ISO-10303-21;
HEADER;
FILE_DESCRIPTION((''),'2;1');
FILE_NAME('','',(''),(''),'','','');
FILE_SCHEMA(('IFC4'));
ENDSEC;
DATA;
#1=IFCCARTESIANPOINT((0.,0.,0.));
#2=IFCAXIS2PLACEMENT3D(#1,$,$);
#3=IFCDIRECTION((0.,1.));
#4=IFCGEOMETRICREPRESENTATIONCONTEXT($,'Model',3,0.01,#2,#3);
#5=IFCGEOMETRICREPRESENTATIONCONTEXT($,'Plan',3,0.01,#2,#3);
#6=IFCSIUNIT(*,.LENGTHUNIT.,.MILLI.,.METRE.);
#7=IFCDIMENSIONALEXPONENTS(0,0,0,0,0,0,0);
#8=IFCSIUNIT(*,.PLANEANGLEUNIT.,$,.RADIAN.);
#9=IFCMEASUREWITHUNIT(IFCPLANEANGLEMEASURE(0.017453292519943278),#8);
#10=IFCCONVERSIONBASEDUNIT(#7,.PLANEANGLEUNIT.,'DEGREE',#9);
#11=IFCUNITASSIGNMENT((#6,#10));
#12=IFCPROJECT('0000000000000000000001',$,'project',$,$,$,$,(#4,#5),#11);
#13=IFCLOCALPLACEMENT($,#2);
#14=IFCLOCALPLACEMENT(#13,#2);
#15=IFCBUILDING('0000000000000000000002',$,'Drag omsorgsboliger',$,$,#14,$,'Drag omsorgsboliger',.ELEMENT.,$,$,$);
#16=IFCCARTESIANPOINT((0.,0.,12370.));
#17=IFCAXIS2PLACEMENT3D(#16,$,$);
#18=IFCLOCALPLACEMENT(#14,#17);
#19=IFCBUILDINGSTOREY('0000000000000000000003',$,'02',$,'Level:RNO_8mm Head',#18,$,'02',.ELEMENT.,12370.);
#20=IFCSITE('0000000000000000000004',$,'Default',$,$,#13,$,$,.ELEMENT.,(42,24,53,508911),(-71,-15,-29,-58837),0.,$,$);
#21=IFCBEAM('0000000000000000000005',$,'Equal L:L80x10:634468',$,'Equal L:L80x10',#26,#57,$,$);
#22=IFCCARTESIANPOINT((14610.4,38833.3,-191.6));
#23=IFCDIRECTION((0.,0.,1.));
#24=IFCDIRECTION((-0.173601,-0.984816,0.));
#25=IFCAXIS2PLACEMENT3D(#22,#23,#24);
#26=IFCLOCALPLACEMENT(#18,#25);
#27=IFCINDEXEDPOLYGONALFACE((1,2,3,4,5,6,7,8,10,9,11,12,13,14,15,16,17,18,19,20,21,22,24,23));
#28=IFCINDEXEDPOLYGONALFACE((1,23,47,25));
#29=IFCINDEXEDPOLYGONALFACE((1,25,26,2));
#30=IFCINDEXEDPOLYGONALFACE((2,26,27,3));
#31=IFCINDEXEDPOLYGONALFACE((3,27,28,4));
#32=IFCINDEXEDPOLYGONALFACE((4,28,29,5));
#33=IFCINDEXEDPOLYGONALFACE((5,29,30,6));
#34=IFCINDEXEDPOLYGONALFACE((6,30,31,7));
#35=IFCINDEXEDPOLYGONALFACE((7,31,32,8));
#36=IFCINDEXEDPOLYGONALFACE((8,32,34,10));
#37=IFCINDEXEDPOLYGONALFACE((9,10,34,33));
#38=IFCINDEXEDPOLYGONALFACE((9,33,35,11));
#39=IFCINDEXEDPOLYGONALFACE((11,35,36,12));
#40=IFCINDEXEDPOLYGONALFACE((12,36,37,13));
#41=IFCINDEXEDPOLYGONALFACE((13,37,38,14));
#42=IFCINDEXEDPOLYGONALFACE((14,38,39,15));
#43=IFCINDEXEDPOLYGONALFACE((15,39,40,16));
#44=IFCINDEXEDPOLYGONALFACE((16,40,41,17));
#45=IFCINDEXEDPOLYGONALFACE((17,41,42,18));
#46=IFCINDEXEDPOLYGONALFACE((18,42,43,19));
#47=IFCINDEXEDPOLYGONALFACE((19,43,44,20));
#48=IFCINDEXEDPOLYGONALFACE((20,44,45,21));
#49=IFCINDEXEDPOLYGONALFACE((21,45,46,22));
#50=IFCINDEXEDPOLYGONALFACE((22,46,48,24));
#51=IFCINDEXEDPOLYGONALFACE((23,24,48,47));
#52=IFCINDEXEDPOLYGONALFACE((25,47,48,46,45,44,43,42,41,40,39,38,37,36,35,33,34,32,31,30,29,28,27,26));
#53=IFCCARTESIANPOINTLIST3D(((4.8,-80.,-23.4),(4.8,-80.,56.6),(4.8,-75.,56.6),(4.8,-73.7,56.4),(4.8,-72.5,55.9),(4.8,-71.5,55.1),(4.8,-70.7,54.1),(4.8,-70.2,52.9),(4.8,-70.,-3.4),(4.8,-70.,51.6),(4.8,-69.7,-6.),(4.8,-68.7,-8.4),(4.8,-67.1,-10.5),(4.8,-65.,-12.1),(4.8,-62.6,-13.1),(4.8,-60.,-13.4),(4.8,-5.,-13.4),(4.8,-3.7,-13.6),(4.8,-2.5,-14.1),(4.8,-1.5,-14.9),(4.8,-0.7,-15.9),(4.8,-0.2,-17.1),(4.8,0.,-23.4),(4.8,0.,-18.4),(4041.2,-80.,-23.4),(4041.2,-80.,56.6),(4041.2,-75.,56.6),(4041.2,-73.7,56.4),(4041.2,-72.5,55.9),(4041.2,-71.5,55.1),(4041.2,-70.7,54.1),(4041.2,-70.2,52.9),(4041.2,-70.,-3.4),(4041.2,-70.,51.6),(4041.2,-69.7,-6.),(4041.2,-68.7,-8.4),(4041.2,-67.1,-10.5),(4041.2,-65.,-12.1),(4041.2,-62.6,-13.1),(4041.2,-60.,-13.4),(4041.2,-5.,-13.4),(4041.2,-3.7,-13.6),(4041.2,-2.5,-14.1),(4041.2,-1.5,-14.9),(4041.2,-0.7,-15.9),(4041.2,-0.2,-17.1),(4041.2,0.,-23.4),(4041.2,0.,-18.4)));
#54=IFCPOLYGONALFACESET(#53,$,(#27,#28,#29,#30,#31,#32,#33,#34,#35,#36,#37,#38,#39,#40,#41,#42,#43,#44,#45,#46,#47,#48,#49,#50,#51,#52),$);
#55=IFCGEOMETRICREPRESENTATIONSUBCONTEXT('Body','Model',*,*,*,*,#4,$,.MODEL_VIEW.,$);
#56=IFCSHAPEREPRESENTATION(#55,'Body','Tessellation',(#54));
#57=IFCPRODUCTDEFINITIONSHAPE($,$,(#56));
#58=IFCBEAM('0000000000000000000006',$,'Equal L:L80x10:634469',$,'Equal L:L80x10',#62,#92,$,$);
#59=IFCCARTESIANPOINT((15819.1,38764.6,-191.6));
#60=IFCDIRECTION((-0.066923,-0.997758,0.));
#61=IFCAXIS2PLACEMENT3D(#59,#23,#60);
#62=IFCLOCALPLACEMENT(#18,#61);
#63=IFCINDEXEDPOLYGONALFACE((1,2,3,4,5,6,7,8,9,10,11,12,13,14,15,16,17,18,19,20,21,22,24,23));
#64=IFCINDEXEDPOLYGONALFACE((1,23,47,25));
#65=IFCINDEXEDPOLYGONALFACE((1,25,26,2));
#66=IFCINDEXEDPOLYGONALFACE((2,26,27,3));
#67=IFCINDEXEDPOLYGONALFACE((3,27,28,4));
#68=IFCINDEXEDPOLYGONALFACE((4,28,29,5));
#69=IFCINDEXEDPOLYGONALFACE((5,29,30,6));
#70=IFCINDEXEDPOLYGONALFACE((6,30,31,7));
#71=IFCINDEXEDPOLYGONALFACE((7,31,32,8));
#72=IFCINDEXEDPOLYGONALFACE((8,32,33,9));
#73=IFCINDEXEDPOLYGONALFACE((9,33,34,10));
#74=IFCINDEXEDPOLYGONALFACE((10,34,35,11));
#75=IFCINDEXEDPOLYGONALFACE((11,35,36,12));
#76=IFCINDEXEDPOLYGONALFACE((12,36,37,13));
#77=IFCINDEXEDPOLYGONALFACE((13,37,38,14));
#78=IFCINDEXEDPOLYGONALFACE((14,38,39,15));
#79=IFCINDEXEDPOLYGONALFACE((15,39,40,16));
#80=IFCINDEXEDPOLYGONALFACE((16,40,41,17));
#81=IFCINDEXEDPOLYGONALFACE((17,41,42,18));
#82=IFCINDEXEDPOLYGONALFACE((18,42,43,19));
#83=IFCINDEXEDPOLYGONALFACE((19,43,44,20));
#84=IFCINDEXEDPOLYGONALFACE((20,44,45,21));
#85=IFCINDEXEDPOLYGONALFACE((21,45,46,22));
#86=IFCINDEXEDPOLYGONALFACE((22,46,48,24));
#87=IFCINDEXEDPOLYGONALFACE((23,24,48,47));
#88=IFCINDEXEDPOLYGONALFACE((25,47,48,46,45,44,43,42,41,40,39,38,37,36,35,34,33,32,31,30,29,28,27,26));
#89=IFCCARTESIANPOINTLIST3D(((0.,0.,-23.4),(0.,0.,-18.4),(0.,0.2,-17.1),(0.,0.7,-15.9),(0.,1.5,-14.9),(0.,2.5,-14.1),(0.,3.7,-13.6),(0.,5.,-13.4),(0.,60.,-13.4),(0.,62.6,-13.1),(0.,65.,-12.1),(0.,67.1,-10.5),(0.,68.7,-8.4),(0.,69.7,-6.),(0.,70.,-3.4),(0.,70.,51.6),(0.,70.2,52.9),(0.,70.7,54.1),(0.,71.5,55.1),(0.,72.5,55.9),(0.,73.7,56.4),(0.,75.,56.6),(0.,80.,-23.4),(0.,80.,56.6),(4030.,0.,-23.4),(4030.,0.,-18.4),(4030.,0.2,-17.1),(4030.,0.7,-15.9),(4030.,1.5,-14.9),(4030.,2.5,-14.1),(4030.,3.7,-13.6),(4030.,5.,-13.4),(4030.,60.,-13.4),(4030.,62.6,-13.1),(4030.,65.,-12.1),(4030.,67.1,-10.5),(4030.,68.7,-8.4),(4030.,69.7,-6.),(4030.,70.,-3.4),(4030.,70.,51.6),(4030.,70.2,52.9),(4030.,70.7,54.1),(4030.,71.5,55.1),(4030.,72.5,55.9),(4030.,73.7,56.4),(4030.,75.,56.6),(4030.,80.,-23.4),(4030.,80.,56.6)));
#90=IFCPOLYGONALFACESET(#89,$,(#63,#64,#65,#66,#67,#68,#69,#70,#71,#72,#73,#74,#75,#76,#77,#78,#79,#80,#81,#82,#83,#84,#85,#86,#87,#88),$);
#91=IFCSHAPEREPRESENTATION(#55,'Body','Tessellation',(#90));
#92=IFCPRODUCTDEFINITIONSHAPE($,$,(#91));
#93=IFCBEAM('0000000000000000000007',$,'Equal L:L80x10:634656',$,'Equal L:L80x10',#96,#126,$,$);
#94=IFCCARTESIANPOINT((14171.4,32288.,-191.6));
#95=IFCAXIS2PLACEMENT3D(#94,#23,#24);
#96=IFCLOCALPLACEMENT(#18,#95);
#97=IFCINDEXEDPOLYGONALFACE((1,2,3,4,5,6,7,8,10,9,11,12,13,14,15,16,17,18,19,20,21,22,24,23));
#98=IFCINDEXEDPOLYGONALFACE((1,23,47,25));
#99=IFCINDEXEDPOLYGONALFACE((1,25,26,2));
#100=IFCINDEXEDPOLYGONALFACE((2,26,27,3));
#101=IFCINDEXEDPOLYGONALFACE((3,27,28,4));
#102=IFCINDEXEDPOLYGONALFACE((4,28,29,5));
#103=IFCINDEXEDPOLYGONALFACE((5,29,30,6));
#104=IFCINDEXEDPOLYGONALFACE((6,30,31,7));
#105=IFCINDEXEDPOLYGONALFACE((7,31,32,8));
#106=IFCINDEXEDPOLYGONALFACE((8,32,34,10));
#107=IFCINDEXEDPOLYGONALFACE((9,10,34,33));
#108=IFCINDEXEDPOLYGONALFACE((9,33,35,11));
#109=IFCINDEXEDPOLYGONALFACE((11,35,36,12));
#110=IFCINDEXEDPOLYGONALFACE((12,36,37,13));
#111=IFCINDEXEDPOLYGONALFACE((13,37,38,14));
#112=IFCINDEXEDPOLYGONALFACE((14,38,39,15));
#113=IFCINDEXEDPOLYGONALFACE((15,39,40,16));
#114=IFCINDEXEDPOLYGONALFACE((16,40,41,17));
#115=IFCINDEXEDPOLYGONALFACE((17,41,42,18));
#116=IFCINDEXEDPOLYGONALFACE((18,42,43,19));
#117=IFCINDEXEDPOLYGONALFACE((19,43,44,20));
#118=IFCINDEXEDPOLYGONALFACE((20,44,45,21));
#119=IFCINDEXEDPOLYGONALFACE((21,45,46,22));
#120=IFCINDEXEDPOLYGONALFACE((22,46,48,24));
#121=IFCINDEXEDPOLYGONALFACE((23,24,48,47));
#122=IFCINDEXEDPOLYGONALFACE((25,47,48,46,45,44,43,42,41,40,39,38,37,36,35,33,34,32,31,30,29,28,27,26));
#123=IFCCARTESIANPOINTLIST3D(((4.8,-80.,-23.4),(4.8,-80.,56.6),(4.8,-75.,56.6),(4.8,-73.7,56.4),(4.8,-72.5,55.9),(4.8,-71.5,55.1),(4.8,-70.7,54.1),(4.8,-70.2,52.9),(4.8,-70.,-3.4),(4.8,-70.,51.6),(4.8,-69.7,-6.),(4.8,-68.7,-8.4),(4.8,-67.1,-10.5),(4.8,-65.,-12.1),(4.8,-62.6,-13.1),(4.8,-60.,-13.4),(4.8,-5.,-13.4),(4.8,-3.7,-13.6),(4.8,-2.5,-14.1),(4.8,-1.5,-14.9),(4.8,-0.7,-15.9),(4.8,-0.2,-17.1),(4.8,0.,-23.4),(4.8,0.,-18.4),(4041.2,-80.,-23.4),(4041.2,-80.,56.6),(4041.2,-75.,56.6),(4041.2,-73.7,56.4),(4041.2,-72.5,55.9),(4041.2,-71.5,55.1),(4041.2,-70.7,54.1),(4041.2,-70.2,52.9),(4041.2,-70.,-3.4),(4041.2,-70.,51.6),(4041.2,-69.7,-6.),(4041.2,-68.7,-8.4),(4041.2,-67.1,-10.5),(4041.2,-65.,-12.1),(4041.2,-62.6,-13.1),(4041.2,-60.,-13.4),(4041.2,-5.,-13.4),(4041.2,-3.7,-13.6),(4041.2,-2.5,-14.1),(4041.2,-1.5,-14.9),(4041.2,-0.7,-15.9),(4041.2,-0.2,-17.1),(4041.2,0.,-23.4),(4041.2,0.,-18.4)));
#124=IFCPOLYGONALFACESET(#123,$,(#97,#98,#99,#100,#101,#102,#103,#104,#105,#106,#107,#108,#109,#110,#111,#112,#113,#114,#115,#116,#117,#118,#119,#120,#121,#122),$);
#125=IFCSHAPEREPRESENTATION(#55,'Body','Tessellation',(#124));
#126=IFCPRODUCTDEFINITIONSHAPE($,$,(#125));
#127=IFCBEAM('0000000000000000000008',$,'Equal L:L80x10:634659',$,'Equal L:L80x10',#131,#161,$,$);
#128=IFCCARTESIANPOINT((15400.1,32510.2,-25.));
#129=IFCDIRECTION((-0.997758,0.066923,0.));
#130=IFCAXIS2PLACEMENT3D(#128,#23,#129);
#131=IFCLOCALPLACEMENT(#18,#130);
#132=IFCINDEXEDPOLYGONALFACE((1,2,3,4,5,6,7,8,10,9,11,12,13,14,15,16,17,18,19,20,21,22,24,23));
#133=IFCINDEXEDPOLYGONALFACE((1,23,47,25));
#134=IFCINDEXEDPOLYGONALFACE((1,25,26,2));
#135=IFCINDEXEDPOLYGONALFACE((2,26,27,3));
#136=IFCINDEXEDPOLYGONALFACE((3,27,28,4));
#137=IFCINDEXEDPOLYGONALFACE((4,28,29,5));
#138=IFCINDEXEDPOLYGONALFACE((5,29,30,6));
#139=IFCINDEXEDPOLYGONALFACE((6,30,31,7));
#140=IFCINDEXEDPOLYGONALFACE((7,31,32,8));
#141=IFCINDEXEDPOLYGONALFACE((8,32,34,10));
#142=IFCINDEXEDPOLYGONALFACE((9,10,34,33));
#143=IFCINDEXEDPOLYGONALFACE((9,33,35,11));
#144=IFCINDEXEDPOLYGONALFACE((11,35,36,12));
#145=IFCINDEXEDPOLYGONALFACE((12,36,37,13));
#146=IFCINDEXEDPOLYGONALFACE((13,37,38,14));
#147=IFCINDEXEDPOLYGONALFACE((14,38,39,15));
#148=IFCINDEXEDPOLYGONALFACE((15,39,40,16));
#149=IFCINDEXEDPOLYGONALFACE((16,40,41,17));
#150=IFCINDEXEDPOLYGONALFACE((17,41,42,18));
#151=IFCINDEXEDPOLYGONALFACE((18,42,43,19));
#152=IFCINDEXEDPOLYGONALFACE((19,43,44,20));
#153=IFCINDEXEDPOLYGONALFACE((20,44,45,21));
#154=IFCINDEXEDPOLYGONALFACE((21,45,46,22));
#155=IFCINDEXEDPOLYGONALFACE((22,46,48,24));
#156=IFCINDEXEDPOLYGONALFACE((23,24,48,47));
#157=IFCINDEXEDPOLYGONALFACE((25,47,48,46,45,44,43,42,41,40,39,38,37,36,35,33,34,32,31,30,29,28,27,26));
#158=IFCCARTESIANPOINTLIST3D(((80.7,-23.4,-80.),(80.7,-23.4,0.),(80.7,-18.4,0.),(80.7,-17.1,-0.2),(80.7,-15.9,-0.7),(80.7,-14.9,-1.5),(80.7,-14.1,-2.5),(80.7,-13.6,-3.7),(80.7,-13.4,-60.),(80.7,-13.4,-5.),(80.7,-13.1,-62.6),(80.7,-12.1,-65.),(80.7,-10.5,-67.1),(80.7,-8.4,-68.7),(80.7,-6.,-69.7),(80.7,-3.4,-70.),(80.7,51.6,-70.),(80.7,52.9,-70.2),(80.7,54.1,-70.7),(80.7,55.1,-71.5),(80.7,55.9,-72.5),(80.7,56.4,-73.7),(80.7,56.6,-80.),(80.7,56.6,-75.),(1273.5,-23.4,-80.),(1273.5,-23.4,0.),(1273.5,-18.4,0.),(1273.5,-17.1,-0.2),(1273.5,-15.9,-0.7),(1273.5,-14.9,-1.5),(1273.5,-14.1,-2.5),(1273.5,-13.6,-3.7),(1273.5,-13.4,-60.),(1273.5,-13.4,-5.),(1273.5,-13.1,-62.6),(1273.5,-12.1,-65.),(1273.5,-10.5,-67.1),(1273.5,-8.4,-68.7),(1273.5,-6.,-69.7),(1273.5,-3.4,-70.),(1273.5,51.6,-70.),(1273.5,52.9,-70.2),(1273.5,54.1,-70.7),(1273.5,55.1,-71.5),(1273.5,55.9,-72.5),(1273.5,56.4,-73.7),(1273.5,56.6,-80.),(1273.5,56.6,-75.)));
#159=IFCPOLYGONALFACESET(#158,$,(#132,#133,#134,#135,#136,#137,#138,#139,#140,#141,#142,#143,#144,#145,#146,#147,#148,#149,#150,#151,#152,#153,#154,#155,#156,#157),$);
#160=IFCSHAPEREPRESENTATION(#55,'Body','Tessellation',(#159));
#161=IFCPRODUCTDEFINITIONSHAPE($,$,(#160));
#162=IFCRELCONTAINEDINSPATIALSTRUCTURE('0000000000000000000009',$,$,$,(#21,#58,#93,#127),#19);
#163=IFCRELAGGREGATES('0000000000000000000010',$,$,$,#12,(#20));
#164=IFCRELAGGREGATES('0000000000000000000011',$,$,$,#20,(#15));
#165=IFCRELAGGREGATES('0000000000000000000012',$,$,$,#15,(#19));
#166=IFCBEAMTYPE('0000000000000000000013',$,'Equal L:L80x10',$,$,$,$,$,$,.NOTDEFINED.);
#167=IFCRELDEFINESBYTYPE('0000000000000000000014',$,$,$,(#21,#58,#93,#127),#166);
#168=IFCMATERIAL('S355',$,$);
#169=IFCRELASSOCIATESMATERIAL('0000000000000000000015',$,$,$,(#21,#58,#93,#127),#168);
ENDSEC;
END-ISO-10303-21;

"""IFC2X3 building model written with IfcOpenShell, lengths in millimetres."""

from ifc_helpers import new_model, entity, si_unit, converted_unit, direction, frame, frame_2d, origin, place, context, subcontext, project, spatial, polyline, circle_curve, parameter, trimmed, segment, composite_curve, outline, extrude, material, type_object, element, save


model = new_model("IFC2X3")

# Units and contexts
model_context = context("Model", 3, precision=0.01, world=origin(), true_north=direction((0.0, 1.0)))
plan_context = context("Plan", 3, precision=0.01, world=origin(), true_north=direction((0.0, 1.0)))
body_context = subcontext(model_context, "Body", "Model", "MODEL_VIEW")
ifc_project = project(units=[si_unit("LENGTHUNIT", "METRE", prefix="MILLI"), converted_unit("PLANEANGLEUNIT", "DEGREE", entity("IfcPlaneAngleMeasure", 0.017453292519943278), si_unit("PLANEANGLEUNIT", "RADIAN"), dimensions=[0, 0, 0, 0, 0, 0, 0])], contexts=[model_context, plan_context])

# Site, building, storey
site_placement = place(None, origin())
site = spatial("IfcSite", under=ifc_project, at=site_placement, Name="Default", CompositionType="ELEMENT", RefLatitude=(42, 24, 53, 508911), RefLongitude=(-71, -15, -29, -58837), RefElevation=0.0)
building_placement = place(site_placement, origin())
building = spatial("IfcBuilding", under=site, at=building_placement, Name="Drag omsorgsboliger", LongName="Drag omsorgsboliger", CompositionType="ELEMENT")
storey_placement = place(building_placement, frame((0.0, 0.0, 12370.0)))
storey = spatial("IfcBuildingStorey", under=building, at=storey_placement, Name="02", ObjectType="Level:RNO_8mm Head", LongName="02", CompositionType="ELEMENT", Elevation=12370.0)

# Beams
ifc_material = material(Name="S355")
beam_type_1 = type_object("IfcBeamType", Name="Equal L:L80x10", PredefinedType="NOTDEFINED")
beam_1_placement = place(storey_placement, frame((14610.4, 38833.3, -191.6), z_axis=(0.0, 0.0, 1.0), x_axis=(-0.173601, -0.984816, 0.0)))
element("IfcBeam", 1, at=beam_1_placement, inside=storey, type_object=beam_type_1, material=ifc_material, Name="Equal L:L80x10:634468", ObjectType="Equal L:L80x10", context=body_context, shape_type="SweptSolid", body=[
    extrude(outline(composite_curve([segment(polyline([(-48.9, -31.1), (31.1, -31.1)]), True, "CONTINUOUS"), segment(polyline([(31.1, -31.1), (31.1, 48.9)]), True, "CONTINUOUS"), segment(polyline([(31.1, 48.9), (26.1, 48.9)]), True, "CONTINUOUS"), segment(trimmed(circle_curve(frame_2d((26.1, 43.9), x_axis=(0.0, 1.0)), 5.0), [parameter(0.0)], [parameter(90.0)], True, "PARAMETER"), True, "CONTINUOUS"), segment(polyline([(21.1, 43.9), (21.1, -11.1)]), True, "CONTINUOUS"), segment(trimmed(circle_curve(frame_2d((11.1, -11.1), x_axis=(1.0, 0.0)), 10.0), [parameter(270.0)], [parameter(0.0)], True, "PARAMETER"), False, "CONTINUOUS"), segment(polyline([(11.1, -21.1), (-43.9, -21.1)]), True, "CONTINUOUS"), segment(trimmed(circle_curve(frame_2d((-43.9, -26.1), x_axis=(0.0, 1.0)), 5.0), [parameter(0.0)], [parameter(90.0)], True, "PARAMETER"), True, "CONTINUOUS"), segment(polyline([(-48.9, -26.1), (-48.9, -31.1)]), True, "CONTINUOUS")], self_intersect=False)), frame((4.8, -48.9, 7.7), z_axis=(1.0, 0.0, 0.0), x_axis=(0.0, 0.0, -1.0)), (0.0, 0.0, 1.0), 4036.4),
])
beam_2_placement = place(storey_placement, frame((15819.1, 38764.6, -191.6), z_axis=(0.0, 0.0, 1.0), x_axis=(-0.066923, -0.997758, 0.0)))
element("IfcBeam", 2, at=beam_2_placement, inside=storey, type_object=beam_type_1, material=ifc_material, Name="Equal L:L80x10:634469", ObjectType="Equal L:L80x10", context=body_context, shape_type="SweptSolid", body=[
    extrude(outline(composite_curve([segment(polyline([(26.1, -48.9), (31.1, -48.9)]), True, "CONTINUOUS"), segment(polyline([(31.1, -48.9), (31.1, 31.1)]), True, "CONTINUOUS"), segment(polyline([(31.1, 31.1), (-48.9, 31.1)]), True, "CONTINUOUS"), segment(polyline([(-48.9, 31.1), (-48.9, 26.1)]), True, "CONTINUOUS"), segment(trimmed(circle_curve(frame_2d((-43.9, 26.1), x_axis=(-1.0, 0.0)), 5.0), [parameter(0.0)], [parameter(90.0)], True, "PARAMETER"), True, "CONTINUOUS"), segment(polyline([(-43.9, 21.1), (11.1, 21.1)]), True, "CONTINUOUS"), segment(trimmed(circle_curve(frame_2d((11.1, 11.1), x_axis=(0.0, 1.0)), 10.0), [parameter(270.0)], [parameter(0.0)], True, "PARAMETER"), False, "CONTINUOUS"), segment(polyline([(21.1, 11.1), (21.1, -43.9)]), True, "CONTINUOUS"), segment(trimmed(circle_curve(frame_2d((26.1, -43.9), x_axis=(-1.0, 0.0)), 5.0), [parameter(0.0)], [parameter(90.0)], True, "PARAMETER"), True, "CONTINUOUS")], self_intersect=False)), frame((0.0, 48.9, 7.7), z_axis=(1.0, 0.0, 0.0), x_axis=(0.0, 0.0, -1.0)), (0.0, 0.0, 1.0), 4030.0),
])
beam_3_placement = place(storey_placement, frame((14171.4, 32288.0, -191.6), z_axis=(0.0, 0.0, 1.0), x_axis=(-0.173601, -0.984816, 0.0)))
element("IfcBeam", 3, at=beam_3_placement, inside=storey, type_object=beam_type_1, material=ifc_material, Name="Equal L:L80x10:634656", ObjectType="Equal L:L80x10", context=body_context, shape_type="SweptSolid", body=[
    extrude(outline(composite_curve([segment(polyline([(-48.9, -31.1), (31.1, -31.1)]), True, "CONTINUOUS"), segment(polyline([(31.1, -31.1), (31.1, 48.9)]), True, "CONTINUOUS"), segment(polyline([(31.1, 48.9), (26.1, 48.9)]), True, "CONTINUOUS"), segment(trimmed(circle_curve(frame_2d((26.1, 43.9), x_axis=(0.0, 1.0)), 5.0), [parameter(0.0)], [parameter(90.0)], True, "PARAMETER"), True, "CONTINUOUS"), segment(polyline([(21.1, 43.9), (21.1, -11.1)]), True, "CONTINUOUS"), segment(trimmed(circle_curve(frame_2d((11.1, -11.1), x_axis=(1.0, 0.0)), 10.0), [parameter(270.0)], [parameter(0.0)], True, "PARAMETER"), False, "CONTINUOUS"), segment(polyline([(11.1, -21.1), (-43.9, -21.1)]), True, "CONTINUOUS"), segment(trimmed(circle_curve(frame_2d((-43.9, -26.1), x_axis=(0.0, 1.0)), 5.0), [parameter(0.0)], [parameter(90.0)], True, "PARAMETER"), True, "CONTINUOUS"), segment(polyline([(-48.9, -26.1), (-48.9, -31.1)]), True, "CONTINUOUS")], self_intersect=False)), frame((4.8, -48.9, 7.7), z_axis=(1.0, 0.0, 0.0), x_axis=(0.0, 0.0, -1.0)), (0.0, 0.0, 1.0), 4036.4),
])
beam_4_placement = place(storey_placement, frame((15400.1, 32510.2, -25.0), z_axis=(0.0, 0.0, 1.0), x_axis=(-0.997758, 0.066923, 0.0)))
element("IfcBeam", 4, at=beam_4_placement, inside=storey, type_object=beam_type_1, material=ifc_material, Name="Equal L:L80x10:634659", ObjectType="Equal L:L80x10", context=body_context, shape_type="SweptSolid", body=[
    extrude(outline(composite_curve([segment(polyline([(-48.9, -31.1), (31.1, -31.1)]), True, "CONTINUOUS"), segment(polyline([(31.1, -31.1), (31.1, 48.9)]), True, "CONTINUOUS"), segment(polyline([(31.1, 48.9), (26.1, 48.9)]), True, "CONTINUOUS"), segment(trimmed(circle_curve(frame_2d((26.1, 43.9), x_axis=(0.0, 1.0)), 5.0), [parameter(0.0)], [parameter(90.0)], True, "PARAMETER"), True, "CONTINUOUS"), segment(polyline([(21.1, 43.9), (21.1, -11.1)]), True, "CONTINUOUS"), segment(trimmed(circle_curve(frame_2d((11.1, -11.1), x_axis=(1.0, 0.0)), 10.0), [parameter(270.0)], [parameter(0.0)], True, "PARAMETER"), False, "CONTINUOUS"), segment(polyline([(11.1, -21.1), (-43.9, -21.1)]), True, "CONTINUOUS"), segment(trimmed(circle_curve(frame_2d((-43.9, -26.1), x_axis=(0.0, 1.0)), 5.0), [parameter(0.0)], [parameter(90.0)], True, "PARAMETER"), True, "CONTINUOUS"), segment(polyline([(-48.9, -26.1), (-48.9, -31.1)]), True, "CONTINUOUS")], self_intersect=False)), frame((80.7, 7.7, -48.9), z_axis=(1.0, 0.0, 0.0), x_axis=(0.0, 0.0, -1.0)), (0.0, 0.0, 1.0), 1192.8),
])

save(model, "model.ifc")
